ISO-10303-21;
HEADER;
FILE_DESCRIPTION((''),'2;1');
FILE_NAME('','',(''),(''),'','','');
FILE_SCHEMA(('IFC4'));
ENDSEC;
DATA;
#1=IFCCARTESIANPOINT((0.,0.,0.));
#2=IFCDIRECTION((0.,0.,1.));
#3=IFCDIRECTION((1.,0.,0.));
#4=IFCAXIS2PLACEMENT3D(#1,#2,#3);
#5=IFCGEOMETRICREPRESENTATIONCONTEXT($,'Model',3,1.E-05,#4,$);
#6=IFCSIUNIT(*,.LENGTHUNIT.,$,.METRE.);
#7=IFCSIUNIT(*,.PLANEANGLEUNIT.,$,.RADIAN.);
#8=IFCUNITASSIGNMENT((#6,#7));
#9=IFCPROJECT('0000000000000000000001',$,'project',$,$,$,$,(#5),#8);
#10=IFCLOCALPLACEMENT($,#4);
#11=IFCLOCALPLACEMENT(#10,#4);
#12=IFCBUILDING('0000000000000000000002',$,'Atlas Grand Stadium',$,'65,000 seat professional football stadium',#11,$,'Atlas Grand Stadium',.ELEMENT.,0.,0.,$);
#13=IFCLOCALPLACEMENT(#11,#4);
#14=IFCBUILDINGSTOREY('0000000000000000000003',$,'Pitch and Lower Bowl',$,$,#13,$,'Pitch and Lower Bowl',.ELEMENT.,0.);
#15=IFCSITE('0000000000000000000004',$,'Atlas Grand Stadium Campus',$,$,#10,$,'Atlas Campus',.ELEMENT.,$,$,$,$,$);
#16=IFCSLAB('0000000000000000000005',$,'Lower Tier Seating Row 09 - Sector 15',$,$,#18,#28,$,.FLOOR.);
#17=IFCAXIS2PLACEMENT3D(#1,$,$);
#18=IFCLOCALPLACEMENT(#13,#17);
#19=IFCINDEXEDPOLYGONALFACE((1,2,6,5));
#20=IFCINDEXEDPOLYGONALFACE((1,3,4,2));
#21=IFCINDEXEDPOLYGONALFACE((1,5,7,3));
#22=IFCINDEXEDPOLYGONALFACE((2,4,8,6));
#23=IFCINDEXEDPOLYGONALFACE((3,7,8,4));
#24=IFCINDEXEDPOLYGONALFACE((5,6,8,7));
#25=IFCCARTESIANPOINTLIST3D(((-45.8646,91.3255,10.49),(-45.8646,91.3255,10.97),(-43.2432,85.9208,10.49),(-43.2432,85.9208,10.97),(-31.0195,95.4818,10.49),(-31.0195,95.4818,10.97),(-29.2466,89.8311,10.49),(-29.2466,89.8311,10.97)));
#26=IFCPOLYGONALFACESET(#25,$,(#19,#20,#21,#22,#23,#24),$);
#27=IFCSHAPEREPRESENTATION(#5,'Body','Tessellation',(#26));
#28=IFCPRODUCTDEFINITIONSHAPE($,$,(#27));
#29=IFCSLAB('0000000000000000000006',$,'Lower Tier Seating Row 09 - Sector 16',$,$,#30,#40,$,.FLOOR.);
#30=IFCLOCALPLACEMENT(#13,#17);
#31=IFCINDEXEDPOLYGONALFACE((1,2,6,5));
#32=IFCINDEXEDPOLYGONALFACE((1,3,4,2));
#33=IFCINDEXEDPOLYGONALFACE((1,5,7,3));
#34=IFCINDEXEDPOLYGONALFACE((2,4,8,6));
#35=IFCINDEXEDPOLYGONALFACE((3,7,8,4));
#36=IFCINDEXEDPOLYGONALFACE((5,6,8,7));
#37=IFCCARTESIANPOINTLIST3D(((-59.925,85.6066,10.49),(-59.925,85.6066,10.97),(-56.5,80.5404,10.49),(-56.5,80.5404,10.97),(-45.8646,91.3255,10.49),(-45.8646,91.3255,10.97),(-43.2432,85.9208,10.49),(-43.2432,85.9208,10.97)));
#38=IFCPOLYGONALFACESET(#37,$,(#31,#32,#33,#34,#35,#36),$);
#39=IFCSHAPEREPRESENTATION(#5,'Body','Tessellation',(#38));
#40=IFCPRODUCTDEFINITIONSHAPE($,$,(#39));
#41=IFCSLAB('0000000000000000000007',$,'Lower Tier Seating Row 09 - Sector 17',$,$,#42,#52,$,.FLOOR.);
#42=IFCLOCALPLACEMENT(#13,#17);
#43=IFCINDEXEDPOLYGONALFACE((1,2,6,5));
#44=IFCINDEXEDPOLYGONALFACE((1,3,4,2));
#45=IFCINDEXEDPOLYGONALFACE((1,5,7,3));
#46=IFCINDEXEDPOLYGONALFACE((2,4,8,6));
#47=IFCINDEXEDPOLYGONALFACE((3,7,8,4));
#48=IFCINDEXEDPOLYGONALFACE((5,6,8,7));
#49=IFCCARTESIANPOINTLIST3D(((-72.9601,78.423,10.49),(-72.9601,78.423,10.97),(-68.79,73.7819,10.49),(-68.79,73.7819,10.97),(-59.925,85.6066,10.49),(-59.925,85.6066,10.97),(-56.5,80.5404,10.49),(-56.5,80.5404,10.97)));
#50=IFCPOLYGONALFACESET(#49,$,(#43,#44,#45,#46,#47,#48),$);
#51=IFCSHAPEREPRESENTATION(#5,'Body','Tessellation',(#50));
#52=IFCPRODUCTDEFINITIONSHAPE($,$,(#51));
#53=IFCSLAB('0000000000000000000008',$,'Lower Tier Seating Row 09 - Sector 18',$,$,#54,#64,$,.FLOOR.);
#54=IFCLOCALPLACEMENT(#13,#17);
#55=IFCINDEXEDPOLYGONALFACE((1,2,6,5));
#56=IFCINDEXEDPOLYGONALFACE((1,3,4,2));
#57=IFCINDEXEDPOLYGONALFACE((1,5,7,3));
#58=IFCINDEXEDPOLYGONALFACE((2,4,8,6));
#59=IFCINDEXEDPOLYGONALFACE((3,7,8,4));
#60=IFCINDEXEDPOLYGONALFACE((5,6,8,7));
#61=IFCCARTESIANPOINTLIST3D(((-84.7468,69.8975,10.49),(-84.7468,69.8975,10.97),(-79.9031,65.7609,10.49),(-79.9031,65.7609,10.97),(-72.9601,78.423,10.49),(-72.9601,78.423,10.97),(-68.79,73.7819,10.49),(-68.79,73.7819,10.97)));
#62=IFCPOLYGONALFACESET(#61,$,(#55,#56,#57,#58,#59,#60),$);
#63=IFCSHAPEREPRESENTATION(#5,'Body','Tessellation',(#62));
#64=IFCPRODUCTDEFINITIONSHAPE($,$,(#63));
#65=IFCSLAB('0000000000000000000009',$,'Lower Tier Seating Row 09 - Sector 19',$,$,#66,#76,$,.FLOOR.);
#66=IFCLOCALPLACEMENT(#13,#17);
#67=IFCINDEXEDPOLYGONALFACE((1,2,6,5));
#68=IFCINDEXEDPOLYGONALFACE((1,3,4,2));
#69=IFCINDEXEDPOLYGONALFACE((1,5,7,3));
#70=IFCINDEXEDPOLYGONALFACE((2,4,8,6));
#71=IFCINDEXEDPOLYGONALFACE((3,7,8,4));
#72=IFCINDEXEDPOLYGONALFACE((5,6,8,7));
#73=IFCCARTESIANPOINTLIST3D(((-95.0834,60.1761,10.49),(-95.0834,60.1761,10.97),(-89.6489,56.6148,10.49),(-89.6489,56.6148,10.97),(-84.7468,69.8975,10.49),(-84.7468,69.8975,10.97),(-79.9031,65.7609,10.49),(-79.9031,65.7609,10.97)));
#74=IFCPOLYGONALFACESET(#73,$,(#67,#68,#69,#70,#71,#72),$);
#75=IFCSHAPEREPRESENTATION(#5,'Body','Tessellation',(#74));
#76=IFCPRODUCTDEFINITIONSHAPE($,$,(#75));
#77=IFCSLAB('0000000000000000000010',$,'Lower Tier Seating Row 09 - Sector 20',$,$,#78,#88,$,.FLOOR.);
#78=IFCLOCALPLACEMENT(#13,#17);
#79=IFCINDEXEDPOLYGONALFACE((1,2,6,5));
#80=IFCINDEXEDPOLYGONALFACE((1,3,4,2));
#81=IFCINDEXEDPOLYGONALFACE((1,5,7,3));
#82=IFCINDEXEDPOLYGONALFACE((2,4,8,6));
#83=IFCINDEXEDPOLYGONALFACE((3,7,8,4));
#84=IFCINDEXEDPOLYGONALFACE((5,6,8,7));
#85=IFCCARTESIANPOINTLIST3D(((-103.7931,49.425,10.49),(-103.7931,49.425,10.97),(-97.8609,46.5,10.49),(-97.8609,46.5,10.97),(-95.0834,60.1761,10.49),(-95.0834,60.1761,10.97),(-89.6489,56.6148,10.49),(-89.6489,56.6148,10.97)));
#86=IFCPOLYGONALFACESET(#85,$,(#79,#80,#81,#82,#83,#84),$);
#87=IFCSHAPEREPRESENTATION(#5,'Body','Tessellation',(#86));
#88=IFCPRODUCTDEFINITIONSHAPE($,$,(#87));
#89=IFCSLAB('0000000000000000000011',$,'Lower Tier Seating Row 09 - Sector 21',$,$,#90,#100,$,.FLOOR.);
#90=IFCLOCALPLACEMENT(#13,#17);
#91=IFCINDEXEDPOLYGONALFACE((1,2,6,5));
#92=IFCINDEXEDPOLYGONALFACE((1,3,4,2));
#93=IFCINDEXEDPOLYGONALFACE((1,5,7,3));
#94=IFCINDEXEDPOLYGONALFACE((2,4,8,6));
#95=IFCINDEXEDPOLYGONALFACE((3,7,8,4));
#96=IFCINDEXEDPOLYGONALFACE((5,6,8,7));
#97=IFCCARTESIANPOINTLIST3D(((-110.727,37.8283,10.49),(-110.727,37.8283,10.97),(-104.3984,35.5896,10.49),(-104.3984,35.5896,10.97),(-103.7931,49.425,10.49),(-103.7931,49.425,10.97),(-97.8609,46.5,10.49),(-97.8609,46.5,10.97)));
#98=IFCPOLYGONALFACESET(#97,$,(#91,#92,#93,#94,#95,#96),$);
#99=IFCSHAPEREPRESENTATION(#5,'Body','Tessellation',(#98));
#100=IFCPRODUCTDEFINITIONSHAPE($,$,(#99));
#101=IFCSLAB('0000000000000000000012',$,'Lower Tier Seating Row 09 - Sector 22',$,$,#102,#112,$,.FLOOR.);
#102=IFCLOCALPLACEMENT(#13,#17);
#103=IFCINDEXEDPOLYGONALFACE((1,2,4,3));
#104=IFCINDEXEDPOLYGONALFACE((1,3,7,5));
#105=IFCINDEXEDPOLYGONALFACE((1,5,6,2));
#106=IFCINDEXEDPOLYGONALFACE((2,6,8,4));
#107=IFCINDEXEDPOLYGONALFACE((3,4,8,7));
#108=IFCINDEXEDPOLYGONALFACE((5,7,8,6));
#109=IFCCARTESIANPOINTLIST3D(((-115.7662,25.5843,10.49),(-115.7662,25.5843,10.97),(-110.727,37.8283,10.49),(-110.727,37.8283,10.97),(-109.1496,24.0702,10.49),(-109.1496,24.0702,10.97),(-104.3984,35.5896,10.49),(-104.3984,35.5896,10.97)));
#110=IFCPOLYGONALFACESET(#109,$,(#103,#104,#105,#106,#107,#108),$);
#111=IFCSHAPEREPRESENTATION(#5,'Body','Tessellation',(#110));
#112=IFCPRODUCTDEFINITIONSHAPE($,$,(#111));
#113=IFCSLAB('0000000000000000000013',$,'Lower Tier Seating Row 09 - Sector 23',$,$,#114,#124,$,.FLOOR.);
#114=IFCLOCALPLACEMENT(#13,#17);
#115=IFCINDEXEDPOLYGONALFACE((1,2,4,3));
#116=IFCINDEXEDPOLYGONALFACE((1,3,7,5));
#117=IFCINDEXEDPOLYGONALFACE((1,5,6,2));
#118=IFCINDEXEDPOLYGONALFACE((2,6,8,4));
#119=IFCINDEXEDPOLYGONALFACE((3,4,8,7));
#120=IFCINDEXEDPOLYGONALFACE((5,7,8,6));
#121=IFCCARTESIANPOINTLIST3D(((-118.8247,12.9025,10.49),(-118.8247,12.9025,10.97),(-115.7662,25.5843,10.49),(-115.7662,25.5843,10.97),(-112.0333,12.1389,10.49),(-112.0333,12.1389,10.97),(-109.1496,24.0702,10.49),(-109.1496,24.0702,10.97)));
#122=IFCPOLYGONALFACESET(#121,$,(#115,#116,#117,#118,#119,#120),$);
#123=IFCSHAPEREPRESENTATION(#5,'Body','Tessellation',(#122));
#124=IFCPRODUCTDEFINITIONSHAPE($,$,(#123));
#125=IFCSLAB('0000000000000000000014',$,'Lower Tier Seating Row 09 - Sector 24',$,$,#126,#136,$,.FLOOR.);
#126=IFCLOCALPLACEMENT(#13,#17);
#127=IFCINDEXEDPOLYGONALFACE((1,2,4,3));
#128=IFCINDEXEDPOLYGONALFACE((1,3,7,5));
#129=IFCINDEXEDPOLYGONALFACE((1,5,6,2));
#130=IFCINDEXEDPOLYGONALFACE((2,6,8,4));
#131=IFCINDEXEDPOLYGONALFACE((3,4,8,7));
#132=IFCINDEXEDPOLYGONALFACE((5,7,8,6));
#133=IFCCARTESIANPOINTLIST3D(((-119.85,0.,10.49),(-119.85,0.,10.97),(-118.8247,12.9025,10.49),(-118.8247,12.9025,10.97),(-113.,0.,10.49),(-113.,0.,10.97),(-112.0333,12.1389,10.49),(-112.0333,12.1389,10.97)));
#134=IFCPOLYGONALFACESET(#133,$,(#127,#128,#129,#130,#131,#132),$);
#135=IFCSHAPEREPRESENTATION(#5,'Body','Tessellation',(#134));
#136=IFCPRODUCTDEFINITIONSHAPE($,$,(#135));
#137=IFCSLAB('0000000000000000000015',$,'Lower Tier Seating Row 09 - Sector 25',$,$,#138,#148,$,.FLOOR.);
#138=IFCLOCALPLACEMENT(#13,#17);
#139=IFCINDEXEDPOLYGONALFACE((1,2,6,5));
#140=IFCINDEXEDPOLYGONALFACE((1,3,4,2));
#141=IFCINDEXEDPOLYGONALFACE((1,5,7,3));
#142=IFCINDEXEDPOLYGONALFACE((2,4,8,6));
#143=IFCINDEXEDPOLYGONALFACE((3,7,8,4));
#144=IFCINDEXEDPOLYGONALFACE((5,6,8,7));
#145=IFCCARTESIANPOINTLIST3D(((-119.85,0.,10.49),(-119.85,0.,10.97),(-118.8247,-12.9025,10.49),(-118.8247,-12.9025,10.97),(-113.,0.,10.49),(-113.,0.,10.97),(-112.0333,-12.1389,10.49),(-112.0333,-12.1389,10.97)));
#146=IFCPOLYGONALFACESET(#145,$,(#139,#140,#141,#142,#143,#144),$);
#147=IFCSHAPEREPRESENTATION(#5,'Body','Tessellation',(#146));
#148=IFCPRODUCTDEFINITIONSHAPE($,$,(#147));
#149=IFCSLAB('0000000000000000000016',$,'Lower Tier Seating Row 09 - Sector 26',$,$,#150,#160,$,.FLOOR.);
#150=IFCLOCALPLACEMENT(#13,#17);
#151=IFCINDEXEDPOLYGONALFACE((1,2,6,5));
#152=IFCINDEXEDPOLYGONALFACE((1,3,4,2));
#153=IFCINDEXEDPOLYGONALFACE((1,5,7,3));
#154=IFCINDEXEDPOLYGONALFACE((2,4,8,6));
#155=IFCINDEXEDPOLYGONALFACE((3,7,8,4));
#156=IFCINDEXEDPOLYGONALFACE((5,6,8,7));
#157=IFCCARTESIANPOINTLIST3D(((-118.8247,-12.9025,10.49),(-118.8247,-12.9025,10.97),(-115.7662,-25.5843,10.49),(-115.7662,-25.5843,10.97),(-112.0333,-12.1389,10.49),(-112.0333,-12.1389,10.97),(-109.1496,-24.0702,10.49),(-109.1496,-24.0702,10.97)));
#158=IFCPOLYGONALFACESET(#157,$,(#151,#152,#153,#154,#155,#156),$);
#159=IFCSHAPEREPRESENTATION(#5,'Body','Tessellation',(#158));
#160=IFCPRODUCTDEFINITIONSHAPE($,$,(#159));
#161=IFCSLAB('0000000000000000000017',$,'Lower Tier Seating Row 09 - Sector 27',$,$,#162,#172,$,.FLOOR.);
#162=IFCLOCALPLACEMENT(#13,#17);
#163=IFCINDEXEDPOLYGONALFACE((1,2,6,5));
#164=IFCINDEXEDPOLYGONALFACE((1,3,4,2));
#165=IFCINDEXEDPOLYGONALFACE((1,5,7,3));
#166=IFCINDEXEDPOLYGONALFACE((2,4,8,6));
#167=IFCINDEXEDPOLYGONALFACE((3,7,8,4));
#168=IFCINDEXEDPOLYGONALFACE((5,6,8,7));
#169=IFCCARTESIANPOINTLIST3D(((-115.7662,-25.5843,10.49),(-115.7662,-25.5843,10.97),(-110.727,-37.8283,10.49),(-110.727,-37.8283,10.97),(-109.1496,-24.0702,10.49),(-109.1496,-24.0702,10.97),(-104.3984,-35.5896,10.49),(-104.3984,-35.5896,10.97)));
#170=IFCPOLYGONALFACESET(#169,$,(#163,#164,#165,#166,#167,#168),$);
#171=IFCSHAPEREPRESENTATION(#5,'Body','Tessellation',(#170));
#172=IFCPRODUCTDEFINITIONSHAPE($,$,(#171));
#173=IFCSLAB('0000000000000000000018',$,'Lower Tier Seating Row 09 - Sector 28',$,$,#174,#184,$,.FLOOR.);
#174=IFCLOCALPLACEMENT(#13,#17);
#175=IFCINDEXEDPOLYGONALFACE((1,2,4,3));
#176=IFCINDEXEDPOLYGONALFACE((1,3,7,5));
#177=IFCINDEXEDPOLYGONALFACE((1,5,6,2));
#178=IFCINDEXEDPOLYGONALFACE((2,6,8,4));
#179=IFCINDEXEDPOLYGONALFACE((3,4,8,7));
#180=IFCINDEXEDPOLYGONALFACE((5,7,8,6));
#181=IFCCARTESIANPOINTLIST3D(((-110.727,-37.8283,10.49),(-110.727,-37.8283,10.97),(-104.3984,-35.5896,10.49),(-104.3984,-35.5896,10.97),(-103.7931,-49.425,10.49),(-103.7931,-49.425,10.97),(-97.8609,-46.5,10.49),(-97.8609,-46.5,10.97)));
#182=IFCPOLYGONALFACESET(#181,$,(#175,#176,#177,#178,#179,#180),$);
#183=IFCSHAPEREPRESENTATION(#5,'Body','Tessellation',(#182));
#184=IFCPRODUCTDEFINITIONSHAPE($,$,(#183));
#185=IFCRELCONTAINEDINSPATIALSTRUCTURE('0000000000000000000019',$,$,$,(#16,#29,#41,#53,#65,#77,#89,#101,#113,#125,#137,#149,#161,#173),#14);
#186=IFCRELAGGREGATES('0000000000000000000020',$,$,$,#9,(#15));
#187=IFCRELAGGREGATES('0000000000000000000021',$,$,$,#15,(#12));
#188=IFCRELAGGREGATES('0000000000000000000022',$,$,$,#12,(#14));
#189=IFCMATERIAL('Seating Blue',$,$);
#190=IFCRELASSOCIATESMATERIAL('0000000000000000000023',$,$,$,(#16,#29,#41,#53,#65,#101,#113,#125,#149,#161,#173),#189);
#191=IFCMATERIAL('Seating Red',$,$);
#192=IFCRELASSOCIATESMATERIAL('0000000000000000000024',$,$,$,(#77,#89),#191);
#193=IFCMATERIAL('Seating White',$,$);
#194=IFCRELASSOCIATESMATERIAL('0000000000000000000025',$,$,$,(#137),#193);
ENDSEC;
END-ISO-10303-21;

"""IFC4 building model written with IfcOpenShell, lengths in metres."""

from ifc_helpers import new_model, si_unit, frame, origin_with_axes, place, context, project, spatial, polyline, outline, extrude, material, element, save


model = new_model("IFC4")

# Units and contexts
model_context = context("Model", 3, precision=1e-05, world=origin_with_axes())
ifc_project = project(units=[si_unit("LENGTHUNIT", "METRE"), si_unit("PLANEANGLEUNIT", "RADIAN")], contexts=[model_context])

# Site, building, storey
site_placement = place(None, origin_with_axes())
site = spatial("IfcSite", under=ifc_project, at=site_placement, Name="Atlas Grand Stadium Campus", LongName="Atlas Campus", CompositionType="ELEMENT")
building_placement = place(site_placement, origin_with_axes())
building = spatial("IfcBuilding", under=site, at=building_placement, Name="Atlas Grand Stadium", ObjectType="65,000 seat professional football stadium", LongName="Atlas Grand Stadium", CompositionType="ELEMENT", ElevationOfRefHeight=0.0, ElevationOfTerrain=0.0)
storey_placement = place(building_placement, origin_with_axes())
storey = spatial("IfcBuildingStorey", under=building, at=storey_placement, Name="Pitch and Lower Bowl", LongName="Pitch and Lower Bowl", CompositionType="ELEMENT", Elevation=0.0)

# Slabs
ifc_material_1 = material(Name="Seating White")
ifc_material_2 = material(Name="Seating Red")
ifc_material_3 = material(Name="Seating Blue")
slab_1_placement = place(storey_placement, frame((0.0, 0.0, 10.49), z_axis=(0.0, 0.0, 1.0), x_axis=(1.0, 0.0, 0.0)))
element("IfcSlab", 1, at=slab_1_placement, inside=storey, material=ifc_material_3, Name="Lower Tier Seating Row 09 - Sector 15", PredefinedType="FLOOR", context=model_context, shape_type="SweptSolid", body=[
    extrude(outline(polyline([(-31.0195, 95.4818), (-45.8646, 91.3255), (-43.2432, 85.9208), (-29.2465, 89.8311), (-31.0195, 95.4818)])), origin_with_axes(), (0.0, 0.0, 1.0), 0.48),
])
slab_2_placement = place(storey_placement, frame((0.0, 0.0, 10.49), z_axis=(0.0, 0.0, 1.0), x_axis=(1.0, 0.0, 0.0)))
element("IfcSlab", 2, at=slab_2_placement, inside=storey, material=ifc_material_3, Name="Lower Tier Seating Row 09 - Sector 16", PredefinedType="FLOOR", context=model_context, shape_type="SweptSolid", body=[
    extrude(outline(polyline([(-45.8646, 91.3255), (-59.925, 85.6066), (-56.5, 80.5404), (-43.2432, 85.9208), (-45.8646, 91.3255)])), origin_with_axes(), (0.0, 0.0, 1.0), 0.48),
])
slab_3_placement = place(storey_placement, frame((0.0, 0.0, 10.49), z_axis=(0.0, 0.0, 1.0), x_axis=(1.0, 0.0, 0.0)))
element("IfcSlab", 3, at=slab_3_placement, inside=storey, material=ifc_material_3, Name="Lower Tier Seating Row 09 - Sector 17", PredefinedType="FLOOR", context=model_context, shape_type="SweptSolid", body=[
    extrude(outline(polyline([(-59.925, 85.6066), (-72.9601, 78.423), (-68.79, 73.7819), (-56.5, 80.5404), (-59.925, 85.6066)])), origin_with_axes(), (0.0, 0.0, 1.0), 0.48),
])
slab_4_placement = place(storey_placement, frame((0.0, 0.0, 10.49), z_axis=(0.0, 0.0, 1.0), x_axis=(1.0, 0.0, 0.0)))
element("IfcSlab", 4, at=slab_4_placement, inside=storey, material=ifc_material_3, Name="Lower Tier Seating Row 09 - Sector 18", PredefinedType="FLOOR", context=model_context, shape_type="SweptSolid", body=[
    extrude(outline(polyline([(-72.9601, 78.423), (-84.7468, 69.8975), (-79.9031, 65.7609), (-68.79, 73.7819), (-72.9601, 78.423)])), origin_with_axes(), (0.0, 0.0, 1.0), 0.48),
])
slab_5_placement = place(storey_placement, frame((0.0, 0.0, 10.49), z_axis=(0.0, 0.0, 1.0), x_axis=(1.0, 0.0, 0.0)))
element("IfcSlab", 5, at=slab_5_placement, inside=storey, material=ifc_material_3, Name="Lower Tier Seating Row 09 - Sector 19", PredefinedType="FLOOR", context=model_context, shape_type="SweptSolid", body=[
    extrude(outline(polyline([(-84.7468, 69.8975), (-95.0834, 60.1761), (-89.6489, 56.6148), (-79.9031, 65.7609), (-84.7468, 69.8975)])), origin_with_axes(), (0.0, 0.0, 1.0), 0.48),
])
slab_6_placement = place(storey_placement, frame((0.0, 0.0, 10.49), z_axis=(0.0, 0.0, 1.0), x_axis=(1.0, 0.0, 0.0)))
element("IfcSlab", 6, at=slab_6_placement, inside=storey, material=ifc_material_2, Name="Lower Tier Seating Row 09 - Sector 20", PredefinedType="FLOOR", context=model_context, shape_type="SweptSolid", body=[
    extrude(outline(polyline([(-95.0834, 60.1761), (-103.7931, 49.425), (-97.8609, 46.5), (-89.6489, 56.6148), (-95.0834, 60.1761)])), origin_with_axes(), (0.0, 0.0, 1.0), 0.48),
])
slab_7_placement = place(storey_placement, frame((0.0, 0.0, 10.49), z_axis=(0.0, 0.0, 1.0), x_axis=(1.0, 0.0, 0.0)))
element("IfcSlab", 7, at=slab_7_placement, inside=storey, material=ifc_material_2, Name="Lower Tier Seating Row 09 - Sector 21", PredefinedType="FLOOR", context=model_context, shape_type="SweptSolid", body=[
    extrude(outline(polyline([(-103.7931, 49.425), (-110.727, 37.8283), (-104.3984, 35.5896), (-97.8609, 46.5), (-103.7931, 49.425)])), origin_with_axes(), (0.0, 0.0, 1.0), 0.48),
])
slab_8_placement = place(storey_placement, frame((0.0, 0.0, 10.49), z_axis=(0.0, 0.0, 1.0), x_axis=(1.0, 0.0, 0.0)))
element("IfcSlab", 8, at=slab_8_placement, inside=storey, material=ifc_material_3, Name="Lower Tier Seating Row 09 - Sector 22", PredefinedType="FLOOR", context=model_context, shape_type="SweptSolid", body=[
    extrude(outline(polyline([(-110.727, 37.8283), (-115.7662, 25.5843), (-109.1496, 24.0702), (-104.3984, 35.5896), (-110.727, 37.8283)])), origin_with_axes(), (0.0, 0.0, 1.0), 0.48),
])
slab_9_placement = place(storey_placement, frame((0.0, 0.0, 10.49), z_axis=(0.0, 0.0, 1.0), x_axis=(1.0, 0.0, 0.0)))
element("IfcSlab", 9, at=slab_9_placement, inside=storey, material=ifc_material_3, Name="Lower Tier Seating Row 09 - Sector 23", PredefinedType="FLOOR", context=model_context, shape_type="SweptSolid", body=[
    extrude(outline(polyline([(-115.7662, 25.5843), (-118.8247, 12.9025), (-112.0333, 12.1389), (-109.1496, 24.0702), (-115.7662, 25.5843)])), origin_with_axes(), (0.0, 0.0, 1.0), 0.48),
])
slab_10_placement = place(storey_placement, frame((0.0, 0.0, 10.49), z_axis=(0.0, 0.0, 1.0), x_axis=(1.0, 0.0, 0.0)))
element("IfcSlab", 10, at=slab_10_placement, inside=storey, material=ifc_material_3, Name="Lower Tier Seating Row 09 - Sector 24", PredefinedType="FLOOR", context=model_context, shape_type="SweptSolid", body=[
    extrude(outline(polyline([(-118.8247, 12.9025), (-119.85, 0.0), (-113.0, 0.0), (-112.0333, 12.1389), (-118.8247, 12.9025)])), origin_with_axes(), (0.0, 0.0, 1.0), 0.48),
])
slab_11_placement = place(storey_placement, frame((0.0, 0.0, 10.49), z_axis=(0.0, 0.0, 1.0), x_axis=(1.0, 0.0, 0.0)))
element("IfcSlab", 11, at=slab_11_placement, inside=storey, material=ifc_material_1, Name="Lower Tier Seating Row 09 - Sector 25", PredefinedType="FLOOR", context=model_context, shape_type="SweptSolid", body=[
    extrude(outline(polyline([(-119.85, 0.0), (-118.8247, -12.9025), (-112.0333, -12.1389), (-113.0, 0.0), (-119.85, 0.0)])), origin_with_axes(), (0.0, 0.0, 1.0), 0.48),
])
slab_12_placement = place(storey_placement, frame((0.0, 0.0, 10.49), z_axis=(0.0, 0.0, 1.0), x_axis=(1.0, 0.0, 0.0)))
element("IfcSlab", 12, at=slab_12_placement, inside=storey, material=ifc_material_3, Name="Lower Tier Seating Row 09 - Sector 26", PredefinedType="FLOOR", context=model_context, shape_type="SweptSolid", body=[
    extrude(outline(polyline([(-118.8247, -12.9025), (-115.7662, -25.5843), (-109.1496, -24.0702), (-112.0333, -12.1389), (-118.8247, -12.9025)])), origin_with_axes(), (0.0, 0.0, 1.0), 0.48),
])
slab_13_placement = place(storey_placement, frame((0.0, 0.0, 10.49), z_axis=(0.0, 0.0, 1.0), x_axis=(1.0, 0.0, 0.0)))
element("IfcSlab", 13, at=slab_13_placement, inside=storey, material=ifc_material_3, Name="Lower Tier Seating Row 09 - Sector 27", PredefinedType="FLOOR", context=model_context, shape_type="SweptSolid", body=[
    extrude(outline(polyline([(-115.7662, -25.5843), (-110.727, -37.8283), (-104.3984, -35.5896), (-109.1496, -24.0702), (-115.7662, -25.5843)])), origin_with_axes(), (0.0, 0.0, 1.0), 0.48),
])
slab_14_placement = place(storey_placement, frame((0.0, 0.0, 10.49), z_axis=(0.0, 0.0, 1.0), x_axis=(1.0, 0.0, 0.0)))
element("IfcSlab", 14, at=slab_14_placement, inside=storey, material=ifc_material_3, Name="Lower Tier Seating Row 09 - Sector 28", PredefinedType="FLOOR", context=model_context, shape_type="SweptSolid", body=[
    extrude(outline(polyline([(-110.727, -37.8283), (-103.7931, -49.425), (-97.8609, -46.5), (-104.3984, -35.5896), (-110.727, -37.8283)])), origin_with_axes(), (0.0, 0.0, 1.0), 0.48),
])

save(model, "model.ifc")
